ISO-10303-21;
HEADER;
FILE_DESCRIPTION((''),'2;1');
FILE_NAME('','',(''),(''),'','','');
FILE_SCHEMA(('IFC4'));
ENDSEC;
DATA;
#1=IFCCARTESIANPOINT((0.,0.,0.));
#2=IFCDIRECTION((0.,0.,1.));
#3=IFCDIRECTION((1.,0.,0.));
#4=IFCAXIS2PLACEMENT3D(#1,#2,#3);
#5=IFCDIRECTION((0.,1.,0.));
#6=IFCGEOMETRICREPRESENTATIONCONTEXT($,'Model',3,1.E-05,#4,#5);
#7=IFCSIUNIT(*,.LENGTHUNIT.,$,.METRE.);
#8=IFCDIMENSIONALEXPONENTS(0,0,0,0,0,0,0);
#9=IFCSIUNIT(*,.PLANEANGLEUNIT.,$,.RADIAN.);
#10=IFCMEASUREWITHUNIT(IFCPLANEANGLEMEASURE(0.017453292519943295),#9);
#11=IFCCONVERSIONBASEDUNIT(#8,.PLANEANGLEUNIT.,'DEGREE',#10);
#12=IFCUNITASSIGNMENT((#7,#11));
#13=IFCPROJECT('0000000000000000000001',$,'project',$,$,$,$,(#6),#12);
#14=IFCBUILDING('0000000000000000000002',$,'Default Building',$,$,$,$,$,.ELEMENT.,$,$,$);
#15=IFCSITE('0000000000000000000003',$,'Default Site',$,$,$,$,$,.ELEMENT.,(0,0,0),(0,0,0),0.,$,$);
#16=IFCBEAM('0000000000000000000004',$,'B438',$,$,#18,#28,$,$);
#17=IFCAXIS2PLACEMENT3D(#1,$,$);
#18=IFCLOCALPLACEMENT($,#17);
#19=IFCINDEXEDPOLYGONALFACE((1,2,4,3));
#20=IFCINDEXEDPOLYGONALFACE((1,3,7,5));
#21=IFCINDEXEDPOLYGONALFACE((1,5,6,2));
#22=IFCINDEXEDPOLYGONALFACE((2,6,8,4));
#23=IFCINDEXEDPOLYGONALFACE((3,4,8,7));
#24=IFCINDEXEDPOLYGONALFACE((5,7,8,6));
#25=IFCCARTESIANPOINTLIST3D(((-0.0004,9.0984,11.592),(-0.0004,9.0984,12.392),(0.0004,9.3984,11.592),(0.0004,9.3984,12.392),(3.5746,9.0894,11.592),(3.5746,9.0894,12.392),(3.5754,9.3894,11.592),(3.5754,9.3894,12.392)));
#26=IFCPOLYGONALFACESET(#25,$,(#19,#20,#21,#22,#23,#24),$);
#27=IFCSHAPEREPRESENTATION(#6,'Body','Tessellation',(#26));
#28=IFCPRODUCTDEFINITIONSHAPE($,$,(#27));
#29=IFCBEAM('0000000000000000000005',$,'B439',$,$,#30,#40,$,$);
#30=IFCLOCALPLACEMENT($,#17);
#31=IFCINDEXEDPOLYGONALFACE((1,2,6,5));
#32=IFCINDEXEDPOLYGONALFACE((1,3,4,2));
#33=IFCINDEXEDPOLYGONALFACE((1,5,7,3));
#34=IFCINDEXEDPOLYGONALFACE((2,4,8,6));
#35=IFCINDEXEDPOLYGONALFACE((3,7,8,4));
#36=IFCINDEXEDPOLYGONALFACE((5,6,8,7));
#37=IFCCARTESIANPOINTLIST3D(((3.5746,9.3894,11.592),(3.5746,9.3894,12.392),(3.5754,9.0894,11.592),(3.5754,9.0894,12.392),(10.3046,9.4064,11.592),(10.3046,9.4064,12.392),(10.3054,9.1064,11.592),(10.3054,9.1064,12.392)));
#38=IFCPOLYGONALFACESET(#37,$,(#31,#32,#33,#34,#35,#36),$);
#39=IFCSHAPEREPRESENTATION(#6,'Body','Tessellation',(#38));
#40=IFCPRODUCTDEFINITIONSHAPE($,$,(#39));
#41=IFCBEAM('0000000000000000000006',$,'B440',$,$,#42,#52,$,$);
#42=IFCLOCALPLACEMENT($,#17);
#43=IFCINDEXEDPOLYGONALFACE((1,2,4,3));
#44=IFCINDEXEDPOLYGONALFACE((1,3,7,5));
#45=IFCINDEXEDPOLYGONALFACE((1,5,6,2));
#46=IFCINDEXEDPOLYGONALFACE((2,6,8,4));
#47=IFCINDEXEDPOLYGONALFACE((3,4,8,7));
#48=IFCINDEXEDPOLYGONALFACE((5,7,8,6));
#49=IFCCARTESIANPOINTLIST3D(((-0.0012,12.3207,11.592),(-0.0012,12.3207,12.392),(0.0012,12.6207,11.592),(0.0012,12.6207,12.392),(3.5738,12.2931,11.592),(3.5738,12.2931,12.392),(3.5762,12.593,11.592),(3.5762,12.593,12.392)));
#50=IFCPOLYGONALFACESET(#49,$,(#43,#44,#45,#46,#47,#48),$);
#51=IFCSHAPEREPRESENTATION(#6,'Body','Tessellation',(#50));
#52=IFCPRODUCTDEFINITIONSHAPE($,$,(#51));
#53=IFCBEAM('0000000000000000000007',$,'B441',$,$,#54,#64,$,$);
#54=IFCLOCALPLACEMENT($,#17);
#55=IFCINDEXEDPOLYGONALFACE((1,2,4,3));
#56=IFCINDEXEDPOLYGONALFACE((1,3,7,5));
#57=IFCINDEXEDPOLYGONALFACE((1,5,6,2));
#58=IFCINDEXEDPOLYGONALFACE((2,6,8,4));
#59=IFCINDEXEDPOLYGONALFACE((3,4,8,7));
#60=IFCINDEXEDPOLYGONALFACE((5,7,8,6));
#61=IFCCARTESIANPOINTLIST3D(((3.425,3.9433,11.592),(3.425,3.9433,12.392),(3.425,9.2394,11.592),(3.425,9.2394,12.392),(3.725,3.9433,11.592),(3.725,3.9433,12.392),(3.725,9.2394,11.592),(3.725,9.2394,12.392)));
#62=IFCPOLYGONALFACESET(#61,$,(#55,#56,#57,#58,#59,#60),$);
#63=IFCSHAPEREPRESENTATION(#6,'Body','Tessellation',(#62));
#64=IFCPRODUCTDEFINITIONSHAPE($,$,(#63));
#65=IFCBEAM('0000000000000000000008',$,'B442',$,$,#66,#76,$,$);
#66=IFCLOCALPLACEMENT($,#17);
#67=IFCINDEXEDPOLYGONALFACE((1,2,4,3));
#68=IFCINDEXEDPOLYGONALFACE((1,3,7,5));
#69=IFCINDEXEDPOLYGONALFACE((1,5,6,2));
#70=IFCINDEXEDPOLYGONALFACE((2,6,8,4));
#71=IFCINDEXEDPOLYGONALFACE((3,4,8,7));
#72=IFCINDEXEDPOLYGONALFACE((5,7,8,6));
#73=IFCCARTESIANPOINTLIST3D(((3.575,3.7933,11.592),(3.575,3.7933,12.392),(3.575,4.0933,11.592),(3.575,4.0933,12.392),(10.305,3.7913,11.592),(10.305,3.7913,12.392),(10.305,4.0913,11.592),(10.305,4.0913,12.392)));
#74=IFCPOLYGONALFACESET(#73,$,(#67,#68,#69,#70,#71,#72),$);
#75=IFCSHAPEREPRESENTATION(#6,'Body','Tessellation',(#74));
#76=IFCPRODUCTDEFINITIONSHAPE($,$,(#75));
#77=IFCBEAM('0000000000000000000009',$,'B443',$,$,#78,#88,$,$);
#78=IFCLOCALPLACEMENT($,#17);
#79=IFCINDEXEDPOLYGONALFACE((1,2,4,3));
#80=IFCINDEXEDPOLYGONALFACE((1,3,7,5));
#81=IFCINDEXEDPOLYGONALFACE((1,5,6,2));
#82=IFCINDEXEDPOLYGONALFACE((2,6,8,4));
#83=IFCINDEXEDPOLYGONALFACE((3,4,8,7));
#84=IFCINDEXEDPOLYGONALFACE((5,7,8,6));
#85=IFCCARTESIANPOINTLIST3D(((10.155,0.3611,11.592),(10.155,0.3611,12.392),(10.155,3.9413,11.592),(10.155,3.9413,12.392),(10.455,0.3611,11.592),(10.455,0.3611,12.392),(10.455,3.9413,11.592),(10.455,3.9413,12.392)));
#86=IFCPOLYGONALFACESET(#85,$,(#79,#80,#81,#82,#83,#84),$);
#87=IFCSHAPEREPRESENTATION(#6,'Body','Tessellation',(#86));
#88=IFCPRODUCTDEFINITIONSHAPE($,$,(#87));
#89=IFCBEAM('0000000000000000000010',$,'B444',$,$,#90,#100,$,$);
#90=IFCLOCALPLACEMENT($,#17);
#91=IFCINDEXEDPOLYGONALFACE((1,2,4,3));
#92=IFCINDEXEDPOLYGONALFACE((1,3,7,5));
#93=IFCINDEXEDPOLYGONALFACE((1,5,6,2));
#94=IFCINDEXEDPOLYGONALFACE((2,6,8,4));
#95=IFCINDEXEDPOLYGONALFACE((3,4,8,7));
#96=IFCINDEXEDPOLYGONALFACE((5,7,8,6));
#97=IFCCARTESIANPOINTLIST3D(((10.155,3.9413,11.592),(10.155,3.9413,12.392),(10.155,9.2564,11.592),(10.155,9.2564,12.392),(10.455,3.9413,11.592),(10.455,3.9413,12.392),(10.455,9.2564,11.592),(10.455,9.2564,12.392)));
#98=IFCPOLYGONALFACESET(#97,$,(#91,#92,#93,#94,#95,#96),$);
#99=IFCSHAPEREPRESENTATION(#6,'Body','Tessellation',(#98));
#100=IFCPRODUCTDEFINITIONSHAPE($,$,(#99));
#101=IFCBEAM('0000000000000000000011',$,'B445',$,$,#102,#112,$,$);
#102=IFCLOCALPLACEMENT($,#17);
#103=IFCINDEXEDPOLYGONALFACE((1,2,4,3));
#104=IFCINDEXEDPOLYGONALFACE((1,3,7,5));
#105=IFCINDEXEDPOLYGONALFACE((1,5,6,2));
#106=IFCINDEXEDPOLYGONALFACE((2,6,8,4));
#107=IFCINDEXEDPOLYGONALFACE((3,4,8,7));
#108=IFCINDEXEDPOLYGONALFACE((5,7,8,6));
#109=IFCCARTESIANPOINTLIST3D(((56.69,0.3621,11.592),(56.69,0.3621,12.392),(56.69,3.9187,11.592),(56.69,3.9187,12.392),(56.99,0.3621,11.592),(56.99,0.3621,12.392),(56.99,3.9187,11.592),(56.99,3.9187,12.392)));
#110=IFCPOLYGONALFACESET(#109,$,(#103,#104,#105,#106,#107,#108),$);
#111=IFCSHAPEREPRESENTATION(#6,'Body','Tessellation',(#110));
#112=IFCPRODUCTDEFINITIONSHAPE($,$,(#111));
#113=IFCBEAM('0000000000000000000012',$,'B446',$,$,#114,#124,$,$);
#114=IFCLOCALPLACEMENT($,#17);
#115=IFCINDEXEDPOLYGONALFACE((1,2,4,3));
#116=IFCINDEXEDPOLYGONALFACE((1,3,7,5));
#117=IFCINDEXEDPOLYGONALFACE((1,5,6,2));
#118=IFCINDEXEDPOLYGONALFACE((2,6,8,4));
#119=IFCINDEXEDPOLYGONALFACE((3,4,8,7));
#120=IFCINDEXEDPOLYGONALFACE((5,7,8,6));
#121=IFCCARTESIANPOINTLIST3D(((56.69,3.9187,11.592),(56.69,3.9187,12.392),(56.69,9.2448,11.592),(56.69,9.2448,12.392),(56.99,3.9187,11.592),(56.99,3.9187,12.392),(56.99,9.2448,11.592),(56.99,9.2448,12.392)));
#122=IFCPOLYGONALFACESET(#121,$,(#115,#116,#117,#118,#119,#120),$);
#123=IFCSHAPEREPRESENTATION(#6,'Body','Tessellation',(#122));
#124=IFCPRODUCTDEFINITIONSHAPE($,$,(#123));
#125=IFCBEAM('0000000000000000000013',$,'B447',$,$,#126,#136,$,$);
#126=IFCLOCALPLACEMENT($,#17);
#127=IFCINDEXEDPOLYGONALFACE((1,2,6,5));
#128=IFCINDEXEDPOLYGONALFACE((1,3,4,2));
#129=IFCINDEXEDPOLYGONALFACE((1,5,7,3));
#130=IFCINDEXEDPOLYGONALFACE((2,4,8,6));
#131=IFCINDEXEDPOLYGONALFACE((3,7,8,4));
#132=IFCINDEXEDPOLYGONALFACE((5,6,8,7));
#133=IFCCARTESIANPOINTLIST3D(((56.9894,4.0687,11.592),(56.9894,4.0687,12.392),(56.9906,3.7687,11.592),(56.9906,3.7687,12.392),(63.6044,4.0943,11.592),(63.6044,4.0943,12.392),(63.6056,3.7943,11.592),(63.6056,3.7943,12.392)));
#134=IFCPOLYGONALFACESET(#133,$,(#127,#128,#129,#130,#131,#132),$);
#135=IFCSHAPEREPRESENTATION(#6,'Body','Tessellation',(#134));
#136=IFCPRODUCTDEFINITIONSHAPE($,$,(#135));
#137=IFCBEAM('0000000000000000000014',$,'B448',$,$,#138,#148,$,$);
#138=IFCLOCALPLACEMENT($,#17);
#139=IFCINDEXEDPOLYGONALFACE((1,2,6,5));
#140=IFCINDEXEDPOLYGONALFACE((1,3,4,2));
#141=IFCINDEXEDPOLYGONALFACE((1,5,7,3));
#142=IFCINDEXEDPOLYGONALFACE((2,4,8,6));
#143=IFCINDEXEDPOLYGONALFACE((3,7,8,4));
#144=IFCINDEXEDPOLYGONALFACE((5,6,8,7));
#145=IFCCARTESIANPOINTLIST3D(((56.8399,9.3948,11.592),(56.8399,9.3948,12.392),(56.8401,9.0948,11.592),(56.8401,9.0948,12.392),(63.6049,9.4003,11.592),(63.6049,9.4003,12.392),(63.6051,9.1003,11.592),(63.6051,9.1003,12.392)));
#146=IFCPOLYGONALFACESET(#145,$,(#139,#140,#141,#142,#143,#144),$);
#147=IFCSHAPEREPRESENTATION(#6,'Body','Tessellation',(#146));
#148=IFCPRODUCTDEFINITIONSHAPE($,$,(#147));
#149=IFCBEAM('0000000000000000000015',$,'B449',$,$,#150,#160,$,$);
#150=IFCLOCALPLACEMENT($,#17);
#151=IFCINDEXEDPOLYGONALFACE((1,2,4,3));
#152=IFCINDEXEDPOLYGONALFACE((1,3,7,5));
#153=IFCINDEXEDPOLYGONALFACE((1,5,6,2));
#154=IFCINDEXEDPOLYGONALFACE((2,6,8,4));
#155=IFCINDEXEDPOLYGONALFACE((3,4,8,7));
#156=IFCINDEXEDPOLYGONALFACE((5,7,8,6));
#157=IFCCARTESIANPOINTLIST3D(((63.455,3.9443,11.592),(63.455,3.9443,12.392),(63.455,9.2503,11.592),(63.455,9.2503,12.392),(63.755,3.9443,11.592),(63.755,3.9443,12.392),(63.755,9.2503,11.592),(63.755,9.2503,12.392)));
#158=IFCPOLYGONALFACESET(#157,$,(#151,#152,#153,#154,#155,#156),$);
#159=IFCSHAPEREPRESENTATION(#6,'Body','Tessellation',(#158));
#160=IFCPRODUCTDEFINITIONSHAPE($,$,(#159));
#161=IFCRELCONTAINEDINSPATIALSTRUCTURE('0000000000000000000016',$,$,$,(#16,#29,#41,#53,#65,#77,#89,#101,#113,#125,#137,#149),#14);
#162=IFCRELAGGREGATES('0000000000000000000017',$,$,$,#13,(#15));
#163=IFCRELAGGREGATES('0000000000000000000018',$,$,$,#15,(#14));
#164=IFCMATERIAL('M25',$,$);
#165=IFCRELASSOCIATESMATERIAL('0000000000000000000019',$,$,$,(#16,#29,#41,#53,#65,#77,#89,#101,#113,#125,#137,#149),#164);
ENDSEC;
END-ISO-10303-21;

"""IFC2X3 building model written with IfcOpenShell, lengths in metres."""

from ifc_helpers import new_model, entity, si_unit, converted_unit, direction, frame, frame_2d, origin_with_axes, place, context, project, spatial, rectangle, extrude, material, element, save


model = new_model("IFC2X3")

# Units and contexts
model_context = context("Model", 3, precision=1e-05, world=origin_with_axes(), true_north=direction((0.0, 1.0, 0.0)))
ifc_project = project(units=[si_unit("LENGTHUNIT", "METRE"), converted_unit("PLANEANGLEUNIT", "DEGREE", entity("IfcPlaneAngleMeasure", 0.017453292519943295), si_unit("PLANEANGLEUNIT", "RADIAN"), dimensions=[0, 0, 0, 0, 0, 0, 0])], contexts=[model_context])

# Site, building
site = spatial("IfcSite", under=ifc_project, Name="Default Site", CompositionType="ELEMENT", RefLatitude=(0, 0, 0), RefLongitude=(0, 0, 0), RefElevation=0.0)
building = spatial("IfcBuilding", under=site, Name="Default Building", CompositionType="ELEMENT")

# Beams
ifc_material = material(Name="M25")
placement = place(None, origin_with_axes())
element("IfcBeam", 1, at=placement, inside=building, material=ifc_material, Name="B438", context=model_context, shape_type="SweptSolid", body=[
    extrude(rectangle(XDim=0.3, YDim=0.8, at=frame_2d((0.0, 0.0), x_axis=(0.0, 1.0, 0.0))), frame((0.0, 9.2484, 11.992), z_axis=(0.999997, -0.002499, 0.0), x_axis=(0.0, 0.0, -1.0)), (0.0, 0.0, 1.0), 3.575),
])
element("IfcBeam", 2, at=placement, inside=building, material=ifc_material, Name="B439", context=model_context, shape_type="SweptSolid", body=[
    extrude(rectangle(XDim=0.3, YDim=0.8, at=frame_2d((0.0, 0.0), x_axis=(0.0, 1.0, 0.0))), frame((3.575, 9.2394, 11.992), z_axis=(0.999997, 0.002522, 0.0), x_axis=(0.0, 0.0, -1.0)), (0.0, 0.0, 1.0), 6.73),
])
element("IfcBeam", 3, at=placement, inside=building, material=ifc_material, Name="B440", context=model_context, shape_type="SweptSolid", body=[
    extrude(rectangle(XDim=0.3, YDim=0.8, at=frame_2d((0.0, 0.0), x_axis=(0.0, 1.0, 0.0))), frame((0.0, 12.4707, 11.992), z_axis=(0.99997, -0.007734, 0.0), x_axis=(0.0, 0.0, -1.0)), (0.0, 0.0, 1.0), 3.5751),
])
element("IfcBeam", 4, at=placement, inside=building, material=ifc_material, Name="B441", context=model_context, shape_type="SweptSolid", body=[
    extrude(rectangle(XDim=0.3, YDim=0.8, at=frame_2d((0.0, 0.0), x_axis=(0.0, 1.0, 0.0))), frame((3.575, 3.9433, 11.992), z_axis=(0.0, 1.0, 0.0), x_axis=(0.0, 0.0, -1.0)), (0.0, 0.0, 1.0), 5.2961),
])
element("IfcBeam", 5, at=placement, inside=building, material=ifc_material, Name="B442", context=model_context, shape_type="SweptSolid", body=[
    extrude(rectangle(XDim=0.3, YDim=0.8, at=frame_2d((0.0, 0.0), x_axis=(0.0, 1.0, 0.0))), frame((3.575, 3.9433, 11.992), z_axis=(1.0, -0.000302, 0.0), x_axis=(0.0, 0.0, -1.0)), (0.0, 0.0, 1.0), 6.73),
])
element("IfcBeam", 6, at=placement, inside=building, material=ifc_material, Name="B443", context=model_context, shape_type="SweptSolid", body=[
    extrude(rectangle(XDim=0.3, YDim=0.8, at=frame_2d((0.0, 0.0), x_axis=(0.0, 1.0, 0.0))), frame((10.305, 3.9413, 11.992), z_axis=(0.0, -1.0, 0.0), x_axis=(0.0, 0.0, -1.0)), (0.0, 0.0, 1.0), 3.5802),
])
element("IfcBeam", 7, at=placement, inside=building, material=ifc_material, Name="B444", context=model_context, shape_type="SweptSolid", body=[
    extrude(rectangle(XDim=0.3, YDim=0.8, at=frame_2d((0.0, 0.0), x_axis=(0.0, 1.0, 0.0))), frame((10.305, 3.9413, 11.992), z_axis=(0.0, 1.0, 0.0), x_axis=(0.0, 0.0, -1.0)), (0.0, 0.0, 1.0), 5.3151),
])
element("IfcBeam", 8, at=placement, inside=building, material=ifc_material, Name="B445", context=model_context, shape_type="SweptSolid", body=[
    extrude(rectangle(XDim=0.3, YDim=0.8, at=frame_2d((0.0, 0.0), x_axis=(0.0, 1.0, 0.0))), frame((56.84, 0.3621, 11.992), z_axis=(0.0, 1.0, 0.0), x_axis=(0.0, 0.0, -1.0)), (0.0, 0.0, 1.0), 3.5566),
])
element("IfcBeam", 9, at=placement, inside=building, material=ifc_material, Name="B446", context=model_context, shape_type="SweptSolid", body=[
    extrude(rectangle(XDim=0.3, YDim=0.8, at=frame_2d((0.0, 0.0), x_axis=(0.0, 1.0, 0.0))), frame((56.84, 3.9187, 11.992), z_axis=(0.0, 1.0, 0.0), x_axis=(0.0, 0.0, -1.0)), (0.0, 0.0, 1.0), 5.3261),
])
element("IfcBeam", 10, at=placement, inside=building, material=ifc_material, Name="B447", context=model_context, shape_type="SweptSolid", body=[
    extrude(rectangle(XDim=0.3, YDim=0.8, at=frame_2d((0.0, 0.0), x_axis=(0.0, 1.0, 0.0))), frame((56.99, 3.9187, 11.992), z_axis=(0.999993, 0.003873, 0.0), x_axis=(0.0, 0.0, -1.0)), (0.0, 0.0, 1.0), 6.6151),
])
element("IfcBeam", 11, at=placement, inside=building, material=ifc_material, Name="B448", context=model_context, shape_type="SweptSolid", body=[
    extrude(rectangle(XDim=0.3, YDim=0.8, at=frame_2d((0.0, 0.0), x_axis=(0.0, 1.0, 0.0))), frame((56.84, 9.2448, 11.992), z_axis=(1.0, 0.000816, 0.0), x_axis=(0.0, 0.0, -1.0)), (0.0, 0.0, 1.0), 6.765),
])
element("IfcBeam", 12, at=placement, inside=building, material=ifc_material, Name="B449", context=model_context, shape_type="SweptSolid", body=[
    extrude(rectangle(XDim=0.3, YDim=0.8, at=frame_2d((0.0, 0.0), x_axis=(0.0, 1.0, 0.0))), frame((63.605, 3.9443, 11.992), z_axis=(0.0, 1.0, 0.0), x_axis=(0.0, 0.0, -1.0)), (0.0, 0.0, 1.0), 5.306),
])

save(model, "model.ifc")
